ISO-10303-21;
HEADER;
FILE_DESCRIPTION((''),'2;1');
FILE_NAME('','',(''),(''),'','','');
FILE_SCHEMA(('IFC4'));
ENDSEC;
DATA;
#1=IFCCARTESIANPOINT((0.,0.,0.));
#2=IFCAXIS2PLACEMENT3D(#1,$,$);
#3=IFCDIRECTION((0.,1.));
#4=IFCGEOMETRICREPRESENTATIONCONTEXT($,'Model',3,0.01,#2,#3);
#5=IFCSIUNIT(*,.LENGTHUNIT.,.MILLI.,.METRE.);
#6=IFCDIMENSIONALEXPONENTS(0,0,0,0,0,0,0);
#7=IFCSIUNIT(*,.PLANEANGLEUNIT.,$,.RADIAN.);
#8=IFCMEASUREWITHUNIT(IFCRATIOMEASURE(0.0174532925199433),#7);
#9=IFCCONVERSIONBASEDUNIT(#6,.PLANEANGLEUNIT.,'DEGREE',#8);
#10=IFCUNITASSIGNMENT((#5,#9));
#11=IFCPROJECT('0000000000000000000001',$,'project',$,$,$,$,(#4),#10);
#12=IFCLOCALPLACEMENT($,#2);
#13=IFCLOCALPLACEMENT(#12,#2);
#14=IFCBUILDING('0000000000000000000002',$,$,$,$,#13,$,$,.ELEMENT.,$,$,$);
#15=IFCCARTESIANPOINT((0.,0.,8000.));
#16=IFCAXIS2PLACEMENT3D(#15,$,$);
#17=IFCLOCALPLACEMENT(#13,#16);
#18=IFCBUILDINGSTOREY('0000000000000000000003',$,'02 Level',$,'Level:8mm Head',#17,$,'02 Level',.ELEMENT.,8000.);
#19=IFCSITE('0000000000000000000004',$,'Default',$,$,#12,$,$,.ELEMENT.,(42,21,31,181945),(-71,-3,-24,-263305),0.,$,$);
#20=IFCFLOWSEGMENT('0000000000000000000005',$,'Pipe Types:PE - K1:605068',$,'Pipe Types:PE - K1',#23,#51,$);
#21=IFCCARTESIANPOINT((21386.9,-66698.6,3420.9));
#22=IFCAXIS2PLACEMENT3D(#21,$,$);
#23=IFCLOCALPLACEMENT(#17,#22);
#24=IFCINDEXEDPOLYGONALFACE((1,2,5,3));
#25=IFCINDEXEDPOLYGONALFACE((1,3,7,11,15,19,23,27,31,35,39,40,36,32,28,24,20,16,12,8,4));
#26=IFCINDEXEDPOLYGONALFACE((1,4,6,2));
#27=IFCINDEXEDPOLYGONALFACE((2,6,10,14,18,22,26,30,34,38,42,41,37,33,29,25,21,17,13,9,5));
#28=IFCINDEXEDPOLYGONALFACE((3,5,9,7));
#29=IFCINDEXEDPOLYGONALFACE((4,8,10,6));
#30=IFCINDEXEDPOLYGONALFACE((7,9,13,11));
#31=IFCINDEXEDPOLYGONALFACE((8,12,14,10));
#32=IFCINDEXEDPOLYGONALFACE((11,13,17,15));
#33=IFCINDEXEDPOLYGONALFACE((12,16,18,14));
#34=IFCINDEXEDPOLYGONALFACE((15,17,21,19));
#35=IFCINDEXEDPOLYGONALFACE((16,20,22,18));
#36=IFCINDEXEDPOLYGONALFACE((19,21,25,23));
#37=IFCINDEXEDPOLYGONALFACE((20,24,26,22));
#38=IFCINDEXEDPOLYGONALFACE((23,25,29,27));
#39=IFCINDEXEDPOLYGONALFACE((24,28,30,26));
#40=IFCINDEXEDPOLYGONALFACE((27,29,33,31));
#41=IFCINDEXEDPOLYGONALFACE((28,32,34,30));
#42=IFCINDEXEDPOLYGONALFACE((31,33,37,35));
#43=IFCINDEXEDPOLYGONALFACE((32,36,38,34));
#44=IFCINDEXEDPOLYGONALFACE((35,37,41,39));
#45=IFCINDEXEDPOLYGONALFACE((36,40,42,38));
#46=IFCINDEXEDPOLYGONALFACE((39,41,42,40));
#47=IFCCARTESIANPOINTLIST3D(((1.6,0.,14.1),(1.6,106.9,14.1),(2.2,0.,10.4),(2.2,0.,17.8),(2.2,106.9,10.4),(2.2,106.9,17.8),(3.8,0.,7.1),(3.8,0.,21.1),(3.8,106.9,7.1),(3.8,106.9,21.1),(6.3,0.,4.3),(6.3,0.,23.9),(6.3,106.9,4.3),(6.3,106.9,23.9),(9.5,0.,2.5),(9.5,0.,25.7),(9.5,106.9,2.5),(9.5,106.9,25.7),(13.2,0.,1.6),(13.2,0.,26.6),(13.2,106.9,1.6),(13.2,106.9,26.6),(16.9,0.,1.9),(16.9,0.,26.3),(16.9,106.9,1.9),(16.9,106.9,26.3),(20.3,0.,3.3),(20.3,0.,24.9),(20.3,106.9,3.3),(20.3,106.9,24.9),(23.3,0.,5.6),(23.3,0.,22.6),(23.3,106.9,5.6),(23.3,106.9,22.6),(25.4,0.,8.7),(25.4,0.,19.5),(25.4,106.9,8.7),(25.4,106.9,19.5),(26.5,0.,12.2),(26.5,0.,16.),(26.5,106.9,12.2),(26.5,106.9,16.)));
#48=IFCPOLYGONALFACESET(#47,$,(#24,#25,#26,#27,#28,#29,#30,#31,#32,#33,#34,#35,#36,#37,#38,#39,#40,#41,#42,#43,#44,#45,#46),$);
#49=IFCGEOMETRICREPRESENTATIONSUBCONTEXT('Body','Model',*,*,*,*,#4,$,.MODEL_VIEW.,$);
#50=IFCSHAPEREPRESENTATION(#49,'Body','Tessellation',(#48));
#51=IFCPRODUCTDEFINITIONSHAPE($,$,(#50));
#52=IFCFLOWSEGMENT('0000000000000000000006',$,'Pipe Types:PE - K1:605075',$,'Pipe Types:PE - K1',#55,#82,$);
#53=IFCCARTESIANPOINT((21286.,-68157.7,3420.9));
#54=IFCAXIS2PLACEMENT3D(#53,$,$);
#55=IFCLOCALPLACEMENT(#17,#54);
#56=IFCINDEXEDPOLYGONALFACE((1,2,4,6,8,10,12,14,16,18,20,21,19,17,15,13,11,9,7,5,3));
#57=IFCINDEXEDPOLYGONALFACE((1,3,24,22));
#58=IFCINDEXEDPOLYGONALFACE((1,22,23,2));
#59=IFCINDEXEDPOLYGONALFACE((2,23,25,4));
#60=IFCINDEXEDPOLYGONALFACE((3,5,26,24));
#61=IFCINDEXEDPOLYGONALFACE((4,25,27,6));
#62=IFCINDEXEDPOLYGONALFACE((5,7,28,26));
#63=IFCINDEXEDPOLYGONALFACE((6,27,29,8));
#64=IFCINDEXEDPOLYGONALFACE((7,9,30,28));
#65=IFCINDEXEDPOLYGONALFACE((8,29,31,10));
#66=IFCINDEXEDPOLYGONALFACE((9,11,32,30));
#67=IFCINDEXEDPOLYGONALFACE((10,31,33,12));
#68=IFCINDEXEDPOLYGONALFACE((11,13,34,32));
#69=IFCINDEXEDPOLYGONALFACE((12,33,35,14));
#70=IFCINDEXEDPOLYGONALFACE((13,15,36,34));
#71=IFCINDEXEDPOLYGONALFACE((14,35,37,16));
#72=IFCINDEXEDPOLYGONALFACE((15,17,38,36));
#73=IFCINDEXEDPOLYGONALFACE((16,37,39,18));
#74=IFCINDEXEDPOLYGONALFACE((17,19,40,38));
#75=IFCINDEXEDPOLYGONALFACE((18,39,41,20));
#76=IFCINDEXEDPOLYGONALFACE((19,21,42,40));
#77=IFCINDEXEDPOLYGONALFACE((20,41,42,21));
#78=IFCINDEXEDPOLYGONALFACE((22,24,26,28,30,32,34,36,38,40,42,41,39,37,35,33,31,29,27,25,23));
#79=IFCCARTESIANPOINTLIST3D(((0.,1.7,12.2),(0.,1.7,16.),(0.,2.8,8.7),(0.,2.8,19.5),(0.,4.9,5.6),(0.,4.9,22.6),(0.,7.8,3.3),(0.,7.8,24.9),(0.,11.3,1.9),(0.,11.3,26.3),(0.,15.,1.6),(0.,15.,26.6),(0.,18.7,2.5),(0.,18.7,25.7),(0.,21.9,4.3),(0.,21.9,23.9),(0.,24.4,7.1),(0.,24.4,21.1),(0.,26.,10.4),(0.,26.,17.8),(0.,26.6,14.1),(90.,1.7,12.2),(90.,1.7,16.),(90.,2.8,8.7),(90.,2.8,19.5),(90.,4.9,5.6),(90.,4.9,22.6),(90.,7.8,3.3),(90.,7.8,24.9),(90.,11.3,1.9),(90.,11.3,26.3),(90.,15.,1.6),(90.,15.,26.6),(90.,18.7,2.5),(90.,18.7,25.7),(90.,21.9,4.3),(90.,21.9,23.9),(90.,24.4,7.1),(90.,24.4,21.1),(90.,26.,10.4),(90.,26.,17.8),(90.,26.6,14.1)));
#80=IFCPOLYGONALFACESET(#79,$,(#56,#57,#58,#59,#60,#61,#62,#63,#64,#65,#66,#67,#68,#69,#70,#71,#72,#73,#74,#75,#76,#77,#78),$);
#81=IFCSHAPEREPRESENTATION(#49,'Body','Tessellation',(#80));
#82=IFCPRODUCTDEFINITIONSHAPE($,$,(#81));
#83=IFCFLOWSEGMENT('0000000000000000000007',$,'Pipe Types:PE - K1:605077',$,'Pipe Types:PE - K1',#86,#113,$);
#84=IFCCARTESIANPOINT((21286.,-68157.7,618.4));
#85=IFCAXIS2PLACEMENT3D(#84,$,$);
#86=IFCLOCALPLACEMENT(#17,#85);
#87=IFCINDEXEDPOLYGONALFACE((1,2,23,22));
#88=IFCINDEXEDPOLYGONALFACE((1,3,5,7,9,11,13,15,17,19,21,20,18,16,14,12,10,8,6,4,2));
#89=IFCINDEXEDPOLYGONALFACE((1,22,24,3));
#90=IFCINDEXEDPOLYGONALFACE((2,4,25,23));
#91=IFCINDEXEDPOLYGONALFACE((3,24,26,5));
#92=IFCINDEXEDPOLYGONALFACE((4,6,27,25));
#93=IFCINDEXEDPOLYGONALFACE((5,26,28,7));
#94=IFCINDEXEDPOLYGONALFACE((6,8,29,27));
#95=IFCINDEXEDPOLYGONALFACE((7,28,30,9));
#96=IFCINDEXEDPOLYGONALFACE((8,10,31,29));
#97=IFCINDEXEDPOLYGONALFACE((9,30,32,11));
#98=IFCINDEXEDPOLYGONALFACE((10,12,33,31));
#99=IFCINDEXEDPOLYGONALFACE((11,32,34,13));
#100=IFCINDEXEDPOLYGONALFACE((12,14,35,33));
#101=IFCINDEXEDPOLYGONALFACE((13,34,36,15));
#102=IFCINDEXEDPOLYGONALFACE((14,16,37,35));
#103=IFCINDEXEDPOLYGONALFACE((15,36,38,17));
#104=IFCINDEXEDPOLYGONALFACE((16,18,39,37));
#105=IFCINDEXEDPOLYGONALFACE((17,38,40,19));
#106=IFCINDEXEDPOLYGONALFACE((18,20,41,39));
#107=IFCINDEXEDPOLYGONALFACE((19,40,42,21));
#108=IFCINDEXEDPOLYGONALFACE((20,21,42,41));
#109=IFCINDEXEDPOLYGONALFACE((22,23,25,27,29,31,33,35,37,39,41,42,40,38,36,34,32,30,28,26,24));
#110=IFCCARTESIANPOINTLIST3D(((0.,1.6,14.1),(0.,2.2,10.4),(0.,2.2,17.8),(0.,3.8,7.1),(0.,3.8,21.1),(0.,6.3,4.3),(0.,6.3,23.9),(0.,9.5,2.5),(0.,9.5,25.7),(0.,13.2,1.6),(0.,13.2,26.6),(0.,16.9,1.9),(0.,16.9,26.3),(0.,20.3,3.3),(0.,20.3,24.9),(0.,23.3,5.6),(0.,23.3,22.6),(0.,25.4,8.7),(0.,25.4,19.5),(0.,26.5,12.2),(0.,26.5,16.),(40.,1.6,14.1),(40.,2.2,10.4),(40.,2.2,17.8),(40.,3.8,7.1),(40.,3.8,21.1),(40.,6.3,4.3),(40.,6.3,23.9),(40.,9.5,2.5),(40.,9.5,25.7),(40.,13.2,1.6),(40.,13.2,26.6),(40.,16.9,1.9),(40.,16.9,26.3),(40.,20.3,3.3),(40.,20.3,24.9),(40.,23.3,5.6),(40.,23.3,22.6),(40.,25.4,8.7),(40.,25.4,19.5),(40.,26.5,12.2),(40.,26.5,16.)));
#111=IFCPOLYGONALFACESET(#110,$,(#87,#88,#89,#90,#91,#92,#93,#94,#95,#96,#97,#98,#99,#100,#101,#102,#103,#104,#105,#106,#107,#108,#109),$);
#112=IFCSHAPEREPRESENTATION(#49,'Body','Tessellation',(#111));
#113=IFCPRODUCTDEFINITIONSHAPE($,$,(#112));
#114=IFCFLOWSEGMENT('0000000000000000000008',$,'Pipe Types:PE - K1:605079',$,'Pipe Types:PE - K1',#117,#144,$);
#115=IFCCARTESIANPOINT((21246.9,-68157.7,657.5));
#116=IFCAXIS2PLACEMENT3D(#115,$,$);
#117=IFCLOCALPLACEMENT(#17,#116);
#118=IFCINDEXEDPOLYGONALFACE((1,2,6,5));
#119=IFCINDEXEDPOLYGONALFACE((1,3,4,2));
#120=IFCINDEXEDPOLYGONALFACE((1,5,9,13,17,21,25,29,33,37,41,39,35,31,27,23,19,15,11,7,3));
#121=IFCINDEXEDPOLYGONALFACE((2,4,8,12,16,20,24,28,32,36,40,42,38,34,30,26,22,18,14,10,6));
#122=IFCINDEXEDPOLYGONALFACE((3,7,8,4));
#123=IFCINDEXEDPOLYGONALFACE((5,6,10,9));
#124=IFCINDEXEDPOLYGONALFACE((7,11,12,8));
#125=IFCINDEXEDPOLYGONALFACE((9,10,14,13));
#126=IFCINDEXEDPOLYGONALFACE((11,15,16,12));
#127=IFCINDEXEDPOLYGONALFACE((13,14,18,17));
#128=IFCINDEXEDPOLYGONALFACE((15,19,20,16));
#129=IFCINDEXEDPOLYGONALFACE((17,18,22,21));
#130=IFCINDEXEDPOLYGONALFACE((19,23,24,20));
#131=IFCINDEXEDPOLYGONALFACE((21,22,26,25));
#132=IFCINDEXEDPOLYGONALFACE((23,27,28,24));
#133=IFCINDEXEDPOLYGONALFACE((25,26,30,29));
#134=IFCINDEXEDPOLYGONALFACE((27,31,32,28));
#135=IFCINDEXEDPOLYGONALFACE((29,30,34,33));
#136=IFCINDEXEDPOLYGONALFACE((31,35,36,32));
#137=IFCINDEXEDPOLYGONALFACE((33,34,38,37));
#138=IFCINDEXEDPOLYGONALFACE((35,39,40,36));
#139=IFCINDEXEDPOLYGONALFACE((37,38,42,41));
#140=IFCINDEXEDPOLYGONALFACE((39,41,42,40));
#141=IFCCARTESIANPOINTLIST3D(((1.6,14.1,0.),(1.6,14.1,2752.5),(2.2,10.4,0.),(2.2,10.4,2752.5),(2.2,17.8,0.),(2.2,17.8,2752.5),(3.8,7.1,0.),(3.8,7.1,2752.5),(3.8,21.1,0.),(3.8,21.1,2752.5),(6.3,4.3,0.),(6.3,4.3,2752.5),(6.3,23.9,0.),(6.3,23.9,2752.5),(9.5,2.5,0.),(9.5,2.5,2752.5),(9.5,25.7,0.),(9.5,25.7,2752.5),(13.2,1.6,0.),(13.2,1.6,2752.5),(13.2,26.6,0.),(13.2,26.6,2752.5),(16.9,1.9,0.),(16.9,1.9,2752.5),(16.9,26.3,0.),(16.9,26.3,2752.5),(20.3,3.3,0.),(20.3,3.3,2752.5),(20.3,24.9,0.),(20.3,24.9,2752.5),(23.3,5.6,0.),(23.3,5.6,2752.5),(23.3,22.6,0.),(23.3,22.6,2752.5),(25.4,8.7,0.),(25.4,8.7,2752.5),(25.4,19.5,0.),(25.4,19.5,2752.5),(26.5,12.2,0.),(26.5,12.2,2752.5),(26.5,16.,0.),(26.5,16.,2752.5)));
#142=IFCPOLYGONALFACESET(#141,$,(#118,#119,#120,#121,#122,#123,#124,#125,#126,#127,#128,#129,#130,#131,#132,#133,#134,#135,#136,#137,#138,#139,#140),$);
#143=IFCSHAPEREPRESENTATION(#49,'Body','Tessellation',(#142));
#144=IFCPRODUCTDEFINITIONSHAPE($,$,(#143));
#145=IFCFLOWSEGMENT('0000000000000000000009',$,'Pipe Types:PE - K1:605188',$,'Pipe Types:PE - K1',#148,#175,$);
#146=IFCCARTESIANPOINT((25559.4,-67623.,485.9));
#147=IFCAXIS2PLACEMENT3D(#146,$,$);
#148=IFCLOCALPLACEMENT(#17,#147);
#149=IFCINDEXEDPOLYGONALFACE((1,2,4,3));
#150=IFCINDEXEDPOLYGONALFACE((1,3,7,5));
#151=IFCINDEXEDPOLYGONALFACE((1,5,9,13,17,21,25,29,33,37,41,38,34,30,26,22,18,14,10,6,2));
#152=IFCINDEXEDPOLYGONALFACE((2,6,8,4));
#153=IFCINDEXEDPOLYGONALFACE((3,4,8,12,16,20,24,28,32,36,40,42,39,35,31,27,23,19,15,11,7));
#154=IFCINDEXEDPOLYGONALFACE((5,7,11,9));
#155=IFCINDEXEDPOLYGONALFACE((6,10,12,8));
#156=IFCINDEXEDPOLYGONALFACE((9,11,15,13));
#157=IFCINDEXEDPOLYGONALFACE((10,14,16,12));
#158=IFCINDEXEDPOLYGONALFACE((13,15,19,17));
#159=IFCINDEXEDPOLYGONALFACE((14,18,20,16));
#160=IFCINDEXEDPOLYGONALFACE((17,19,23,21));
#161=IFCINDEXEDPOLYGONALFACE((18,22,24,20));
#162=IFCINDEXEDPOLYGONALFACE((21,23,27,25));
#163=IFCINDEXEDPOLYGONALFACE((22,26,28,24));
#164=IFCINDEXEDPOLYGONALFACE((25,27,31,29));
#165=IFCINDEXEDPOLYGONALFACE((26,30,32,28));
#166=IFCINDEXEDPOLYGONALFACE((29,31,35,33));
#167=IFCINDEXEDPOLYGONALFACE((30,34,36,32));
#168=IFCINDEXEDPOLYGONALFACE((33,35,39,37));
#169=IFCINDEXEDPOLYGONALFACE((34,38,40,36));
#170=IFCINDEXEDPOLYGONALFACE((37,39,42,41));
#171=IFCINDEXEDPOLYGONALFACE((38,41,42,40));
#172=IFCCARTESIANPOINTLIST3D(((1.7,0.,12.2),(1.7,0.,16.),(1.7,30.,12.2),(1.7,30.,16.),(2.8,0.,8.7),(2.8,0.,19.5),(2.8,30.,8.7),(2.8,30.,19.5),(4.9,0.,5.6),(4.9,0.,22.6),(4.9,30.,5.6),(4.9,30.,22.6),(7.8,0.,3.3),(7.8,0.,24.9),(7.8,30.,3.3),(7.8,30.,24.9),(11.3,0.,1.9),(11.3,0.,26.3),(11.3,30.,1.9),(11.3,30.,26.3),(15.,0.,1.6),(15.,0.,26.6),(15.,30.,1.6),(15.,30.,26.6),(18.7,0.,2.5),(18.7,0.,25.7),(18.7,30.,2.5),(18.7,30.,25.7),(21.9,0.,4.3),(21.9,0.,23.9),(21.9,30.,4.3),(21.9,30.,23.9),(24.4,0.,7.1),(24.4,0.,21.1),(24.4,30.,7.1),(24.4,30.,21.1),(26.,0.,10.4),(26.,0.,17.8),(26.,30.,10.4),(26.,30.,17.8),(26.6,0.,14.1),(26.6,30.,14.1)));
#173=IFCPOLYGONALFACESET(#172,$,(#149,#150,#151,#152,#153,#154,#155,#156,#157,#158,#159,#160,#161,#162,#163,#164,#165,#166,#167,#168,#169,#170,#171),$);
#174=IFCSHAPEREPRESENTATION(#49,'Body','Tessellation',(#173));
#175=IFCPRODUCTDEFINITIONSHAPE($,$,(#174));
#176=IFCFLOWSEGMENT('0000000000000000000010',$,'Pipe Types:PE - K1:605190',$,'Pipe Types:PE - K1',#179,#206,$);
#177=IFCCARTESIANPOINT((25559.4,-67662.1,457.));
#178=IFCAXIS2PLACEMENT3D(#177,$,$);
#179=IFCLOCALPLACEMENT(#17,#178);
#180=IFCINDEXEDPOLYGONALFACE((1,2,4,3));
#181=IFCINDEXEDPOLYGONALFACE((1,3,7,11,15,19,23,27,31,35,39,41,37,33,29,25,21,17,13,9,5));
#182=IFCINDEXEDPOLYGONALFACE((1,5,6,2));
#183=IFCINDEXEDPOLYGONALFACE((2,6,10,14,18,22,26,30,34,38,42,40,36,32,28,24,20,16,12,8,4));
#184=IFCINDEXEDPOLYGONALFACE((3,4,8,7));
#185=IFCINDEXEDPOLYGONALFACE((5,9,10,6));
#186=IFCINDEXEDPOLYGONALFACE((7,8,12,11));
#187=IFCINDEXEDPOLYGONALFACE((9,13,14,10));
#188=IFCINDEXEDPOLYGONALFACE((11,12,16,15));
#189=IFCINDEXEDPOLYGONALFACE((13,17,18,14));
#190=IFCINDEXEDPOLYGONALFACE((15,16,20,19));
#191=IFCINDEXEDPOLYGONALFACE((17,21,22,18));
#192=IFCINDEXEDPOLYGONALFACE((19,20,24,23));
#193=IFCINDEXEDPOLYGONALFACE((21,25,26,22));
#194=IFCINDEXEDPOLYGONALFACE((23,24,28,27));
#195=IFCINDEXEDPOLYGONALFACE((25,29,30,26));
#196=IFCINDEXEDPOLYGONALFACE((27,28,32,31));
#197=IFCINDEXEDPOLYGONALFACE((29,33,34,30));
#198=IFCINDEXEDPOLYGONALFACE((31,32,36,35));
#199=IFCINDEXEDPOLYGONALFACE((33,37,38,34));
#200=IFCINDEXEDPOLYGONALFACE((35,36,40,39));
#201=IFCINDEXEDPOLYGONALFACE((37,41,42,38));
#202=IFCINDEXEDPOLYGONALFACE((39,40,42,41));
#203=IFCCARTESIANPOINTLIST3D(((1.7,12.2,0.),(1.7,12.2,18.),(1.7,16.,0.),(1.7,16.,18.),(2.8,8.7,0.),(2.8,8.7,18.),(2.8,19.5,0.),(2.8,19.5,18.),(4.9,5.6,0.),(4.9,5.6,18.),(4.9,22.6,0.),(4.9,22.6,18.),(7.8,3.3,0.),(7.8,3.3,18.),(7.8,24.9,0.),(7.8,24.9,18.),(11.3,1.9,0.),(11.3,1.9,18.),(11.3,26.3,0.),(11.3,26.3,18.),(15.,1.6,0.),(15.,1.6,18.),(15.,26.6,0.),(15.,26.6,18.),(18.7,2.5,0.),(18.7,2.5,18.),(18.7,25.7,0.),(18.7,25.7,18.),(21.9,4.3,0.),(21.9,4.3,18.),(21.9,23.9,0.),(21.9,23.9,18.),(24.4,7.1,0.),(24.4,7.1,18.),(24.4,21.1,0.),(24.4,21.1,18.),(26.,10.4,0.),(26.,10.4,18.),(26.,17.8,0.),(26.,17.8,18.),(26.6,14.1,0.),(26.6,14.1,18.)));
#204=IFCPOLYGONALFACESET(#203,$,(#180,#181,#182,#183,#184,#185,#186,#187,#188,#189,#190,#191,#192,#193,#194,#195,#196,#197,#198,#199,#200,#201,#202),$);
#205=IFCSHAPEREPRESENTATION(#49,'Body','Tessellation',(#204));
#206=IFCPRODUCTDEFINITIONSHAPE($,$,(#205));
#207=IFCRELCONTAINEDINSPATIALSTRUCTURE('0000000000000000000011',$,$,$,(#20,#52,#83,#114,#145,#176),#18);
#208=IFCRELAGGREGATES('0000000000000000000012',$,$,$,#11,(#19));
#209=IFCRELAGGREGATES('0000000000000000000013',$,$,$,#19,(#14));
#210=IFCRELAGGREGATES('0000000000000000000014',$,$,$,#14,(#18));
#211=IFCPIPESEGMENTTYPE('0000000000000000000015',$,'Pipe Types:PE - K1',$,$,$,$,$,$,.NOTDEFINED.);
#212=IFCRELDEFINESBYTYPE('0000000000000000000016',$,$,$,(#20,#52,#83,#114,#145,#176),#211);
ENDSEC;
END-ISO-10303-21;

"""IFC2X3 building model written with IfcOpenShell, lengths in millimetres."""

from ifc_helpers import new_model, entity, si_unit, converted_unit, direction, frame, frame_2d, origin, origin_2d_with_axis, place, context, subcontext, project, spatial, circle, extrude, type_object, element, save


model = new_model("IFC2X3")

# Units and contexts
model_context = context("Model", 3, precision=0.01, world=origin(), true_north=direction((0.0, 1.0)))
body_context = subcontext(model_context, "Body", "Model", "MODEL_VIEW")
ifc_project = project(units=[si_unit("LENGTHUNIT", "METRE", prefix="MILLI"), converted_unit("PLANEANGLEUNIT", "DEGREE", entity("IfcRatioMeasure", 0.0174532925199433), si_unit("PLANEANGLEUNIT", "RADIAN"), dimensions=[0, 0, 0, 0, 0, 0, 0])], contexts=[model_context])

# Site, building, storey
site_placement = place(None, origin())
site = spatial("IfcSite", under=ifc_project, at=site_placement, Name="Default", CompositionType="ELEMENT", RefLatitude=(42, 21, 31, 181945), RefLongitude=(-71, -3, -24, -263305), RefElevation=0.0)
building_placement = place(site_placement, origin())
building = spatial("IfcBuilding", under=site, at=building_placement, CompositionType="ELEMENT")
storey_placement = place(building_placement, frame((0.0, 0.0, 8000.0)))
storey = spatial("IfcBuildingStorey", under=building, at=storey_placement, Name="02 Level", ObjectType="Level:8mm Head", LongName="02 Level", CompositionType="ELEMENT", Elevation=8000.0)

# Flow segments
pipe_segment_type = type_object("IfcPipeSegmentType", Name="Pipe Types:PE - K1", PredefinedType="NOTDEFINED")
flow_segment_1_placement = place(storey_placement, frame((21386.9, -66698.6, 3420.9)))
element("IfcFlowSegment", 1, at=flow_segment_1_placement, inside=storey, type_object=pipe_segment_type, Name="Pipe Types:PE - K1:605068", ObjectType="Pipe Types:PE - K1", context=body_context, shape_type="SweptSolid", body=[
    extrude(circle(Radius=12.5, at=frame_2d((0.0, 0.0), x_axis=(1.0, 0.0))), frame((14.1, 0.0, 14.1), z_axis=(0.0, 1.0, 0.0), x_axis=(-1.0, 0.0, 0.0)), (0.0, 0.0, 1.0), 106.9),
])
flow_segment_2_placement = place(storey_placement, frame((21286.0, -68157.7, 3420.9)))
element("IfcFlowSegment", 2, at=flow_segment_2_placement, inside=storey, type_object=pipe_segment_type, Name="Pipe Types:PE - K1:605075", ObjectType="Pipe Types:PE - K1", context=body_context, shape_type="SweptSolid", body=[
    extrude(circle(Radius=12.5, at=origin_2d_with_axis()), frame((0.0, 14.1, 14.1), z_axis=(1.0, 0.0, 0.0), x_axis=(0.0, 1.0, 0.0)), (0.0, 0.0, 1.0), 90.0),
])
flow_segment_3_placement = place(storey_placement, frame((21286.0, -68157.7, 618.4)))
element("IfcFlowSegment", 3, at=flow_segment_3_placement, inside=storey, type_object=pipe_segment_type, Name="Pipe Types:PE - K1:605077", ObjectType="Pipe Types:PE - K1", context=body_context, shape_type="SweptSolid", body=[
    extrude(circle(Radius=12.5, at=frame_2d((0.0, 0.0), x_axis=(1.0, 0.0))), frame((0.0, 14.1, 14.1), z_axis=(1.0, 0.0, 0.0), x_axis=(0.0, -1.0, 0.0)), (0.0, 0.0, 1.0), 40.0),
])
flow_segment_4_placement = place(storey_placement, frame((21246.9, -68157.7, 657.5)))
element("IfcFlowSegment", 4, at=flow_segment_4_placement, inside=storey, type_object=pipe_segment_type, Name="Pipe Types:PE - K1:605079", ObjectType="Pipe Types:PE - K1", context=body_context, shape_type="SweptSolid", body=[
    extrude(circle(Radius=12.5, at=origin_2d_with_axis()), frame((14.1, 14.1, 0.0), z_axis=(0.0, 0.0, 1.0), x_axis=(-1.0, 0.0, 0.0)), (0.0, 0.0, 1.0), 2752.5),
])
flow_segment_5_placement = place(storey_placement, frame((25559.4, -67623.0, 485.9)))
element("IfcFlowSegment", 5, at=flow_segment_5_placement, inside=storey, type_object=pipe_segment_type, Name="Pipe Types:PE - K1:605188", ObjectType="Pipe Types:PE - K1", context=body_context, shape_type="SweptSolid", body=[
    extrude(circle(Radius=12.5, at=frame_2d((0.0, 0.0), x_axis=(1.0, 0.0))), frame((14.1, 0.0, 14.1), z_axis=(0.0, 1.0, 0.0), x_axis=(1.0, 0.0, 0.0)), (0.0, 0.0, 1.0), 30.0),
])
flow_segment_6_placement = place(storey_placement, frame((25559.4, -67662.1, 457.0)))
element("IfcFlowSegment", 6, at=flow_segment_6_placement, inside=storey, type_object=pipe_segment_type, Name="Pipe Types:PE - K1:605190", ObjectType="Pipe Types:PE - K1", context=body_context, shape_type="SweptSolid", body=[
    extrude(circle(Radius=12.5, at=frame_2d((0.0, 0.0), x_axis=(1.0, 0.0))), frame((14.1, 14.1, 0.0)), (0.0, 0.0, 1.0), 18.0),
])

save(model, "model.ifc")
